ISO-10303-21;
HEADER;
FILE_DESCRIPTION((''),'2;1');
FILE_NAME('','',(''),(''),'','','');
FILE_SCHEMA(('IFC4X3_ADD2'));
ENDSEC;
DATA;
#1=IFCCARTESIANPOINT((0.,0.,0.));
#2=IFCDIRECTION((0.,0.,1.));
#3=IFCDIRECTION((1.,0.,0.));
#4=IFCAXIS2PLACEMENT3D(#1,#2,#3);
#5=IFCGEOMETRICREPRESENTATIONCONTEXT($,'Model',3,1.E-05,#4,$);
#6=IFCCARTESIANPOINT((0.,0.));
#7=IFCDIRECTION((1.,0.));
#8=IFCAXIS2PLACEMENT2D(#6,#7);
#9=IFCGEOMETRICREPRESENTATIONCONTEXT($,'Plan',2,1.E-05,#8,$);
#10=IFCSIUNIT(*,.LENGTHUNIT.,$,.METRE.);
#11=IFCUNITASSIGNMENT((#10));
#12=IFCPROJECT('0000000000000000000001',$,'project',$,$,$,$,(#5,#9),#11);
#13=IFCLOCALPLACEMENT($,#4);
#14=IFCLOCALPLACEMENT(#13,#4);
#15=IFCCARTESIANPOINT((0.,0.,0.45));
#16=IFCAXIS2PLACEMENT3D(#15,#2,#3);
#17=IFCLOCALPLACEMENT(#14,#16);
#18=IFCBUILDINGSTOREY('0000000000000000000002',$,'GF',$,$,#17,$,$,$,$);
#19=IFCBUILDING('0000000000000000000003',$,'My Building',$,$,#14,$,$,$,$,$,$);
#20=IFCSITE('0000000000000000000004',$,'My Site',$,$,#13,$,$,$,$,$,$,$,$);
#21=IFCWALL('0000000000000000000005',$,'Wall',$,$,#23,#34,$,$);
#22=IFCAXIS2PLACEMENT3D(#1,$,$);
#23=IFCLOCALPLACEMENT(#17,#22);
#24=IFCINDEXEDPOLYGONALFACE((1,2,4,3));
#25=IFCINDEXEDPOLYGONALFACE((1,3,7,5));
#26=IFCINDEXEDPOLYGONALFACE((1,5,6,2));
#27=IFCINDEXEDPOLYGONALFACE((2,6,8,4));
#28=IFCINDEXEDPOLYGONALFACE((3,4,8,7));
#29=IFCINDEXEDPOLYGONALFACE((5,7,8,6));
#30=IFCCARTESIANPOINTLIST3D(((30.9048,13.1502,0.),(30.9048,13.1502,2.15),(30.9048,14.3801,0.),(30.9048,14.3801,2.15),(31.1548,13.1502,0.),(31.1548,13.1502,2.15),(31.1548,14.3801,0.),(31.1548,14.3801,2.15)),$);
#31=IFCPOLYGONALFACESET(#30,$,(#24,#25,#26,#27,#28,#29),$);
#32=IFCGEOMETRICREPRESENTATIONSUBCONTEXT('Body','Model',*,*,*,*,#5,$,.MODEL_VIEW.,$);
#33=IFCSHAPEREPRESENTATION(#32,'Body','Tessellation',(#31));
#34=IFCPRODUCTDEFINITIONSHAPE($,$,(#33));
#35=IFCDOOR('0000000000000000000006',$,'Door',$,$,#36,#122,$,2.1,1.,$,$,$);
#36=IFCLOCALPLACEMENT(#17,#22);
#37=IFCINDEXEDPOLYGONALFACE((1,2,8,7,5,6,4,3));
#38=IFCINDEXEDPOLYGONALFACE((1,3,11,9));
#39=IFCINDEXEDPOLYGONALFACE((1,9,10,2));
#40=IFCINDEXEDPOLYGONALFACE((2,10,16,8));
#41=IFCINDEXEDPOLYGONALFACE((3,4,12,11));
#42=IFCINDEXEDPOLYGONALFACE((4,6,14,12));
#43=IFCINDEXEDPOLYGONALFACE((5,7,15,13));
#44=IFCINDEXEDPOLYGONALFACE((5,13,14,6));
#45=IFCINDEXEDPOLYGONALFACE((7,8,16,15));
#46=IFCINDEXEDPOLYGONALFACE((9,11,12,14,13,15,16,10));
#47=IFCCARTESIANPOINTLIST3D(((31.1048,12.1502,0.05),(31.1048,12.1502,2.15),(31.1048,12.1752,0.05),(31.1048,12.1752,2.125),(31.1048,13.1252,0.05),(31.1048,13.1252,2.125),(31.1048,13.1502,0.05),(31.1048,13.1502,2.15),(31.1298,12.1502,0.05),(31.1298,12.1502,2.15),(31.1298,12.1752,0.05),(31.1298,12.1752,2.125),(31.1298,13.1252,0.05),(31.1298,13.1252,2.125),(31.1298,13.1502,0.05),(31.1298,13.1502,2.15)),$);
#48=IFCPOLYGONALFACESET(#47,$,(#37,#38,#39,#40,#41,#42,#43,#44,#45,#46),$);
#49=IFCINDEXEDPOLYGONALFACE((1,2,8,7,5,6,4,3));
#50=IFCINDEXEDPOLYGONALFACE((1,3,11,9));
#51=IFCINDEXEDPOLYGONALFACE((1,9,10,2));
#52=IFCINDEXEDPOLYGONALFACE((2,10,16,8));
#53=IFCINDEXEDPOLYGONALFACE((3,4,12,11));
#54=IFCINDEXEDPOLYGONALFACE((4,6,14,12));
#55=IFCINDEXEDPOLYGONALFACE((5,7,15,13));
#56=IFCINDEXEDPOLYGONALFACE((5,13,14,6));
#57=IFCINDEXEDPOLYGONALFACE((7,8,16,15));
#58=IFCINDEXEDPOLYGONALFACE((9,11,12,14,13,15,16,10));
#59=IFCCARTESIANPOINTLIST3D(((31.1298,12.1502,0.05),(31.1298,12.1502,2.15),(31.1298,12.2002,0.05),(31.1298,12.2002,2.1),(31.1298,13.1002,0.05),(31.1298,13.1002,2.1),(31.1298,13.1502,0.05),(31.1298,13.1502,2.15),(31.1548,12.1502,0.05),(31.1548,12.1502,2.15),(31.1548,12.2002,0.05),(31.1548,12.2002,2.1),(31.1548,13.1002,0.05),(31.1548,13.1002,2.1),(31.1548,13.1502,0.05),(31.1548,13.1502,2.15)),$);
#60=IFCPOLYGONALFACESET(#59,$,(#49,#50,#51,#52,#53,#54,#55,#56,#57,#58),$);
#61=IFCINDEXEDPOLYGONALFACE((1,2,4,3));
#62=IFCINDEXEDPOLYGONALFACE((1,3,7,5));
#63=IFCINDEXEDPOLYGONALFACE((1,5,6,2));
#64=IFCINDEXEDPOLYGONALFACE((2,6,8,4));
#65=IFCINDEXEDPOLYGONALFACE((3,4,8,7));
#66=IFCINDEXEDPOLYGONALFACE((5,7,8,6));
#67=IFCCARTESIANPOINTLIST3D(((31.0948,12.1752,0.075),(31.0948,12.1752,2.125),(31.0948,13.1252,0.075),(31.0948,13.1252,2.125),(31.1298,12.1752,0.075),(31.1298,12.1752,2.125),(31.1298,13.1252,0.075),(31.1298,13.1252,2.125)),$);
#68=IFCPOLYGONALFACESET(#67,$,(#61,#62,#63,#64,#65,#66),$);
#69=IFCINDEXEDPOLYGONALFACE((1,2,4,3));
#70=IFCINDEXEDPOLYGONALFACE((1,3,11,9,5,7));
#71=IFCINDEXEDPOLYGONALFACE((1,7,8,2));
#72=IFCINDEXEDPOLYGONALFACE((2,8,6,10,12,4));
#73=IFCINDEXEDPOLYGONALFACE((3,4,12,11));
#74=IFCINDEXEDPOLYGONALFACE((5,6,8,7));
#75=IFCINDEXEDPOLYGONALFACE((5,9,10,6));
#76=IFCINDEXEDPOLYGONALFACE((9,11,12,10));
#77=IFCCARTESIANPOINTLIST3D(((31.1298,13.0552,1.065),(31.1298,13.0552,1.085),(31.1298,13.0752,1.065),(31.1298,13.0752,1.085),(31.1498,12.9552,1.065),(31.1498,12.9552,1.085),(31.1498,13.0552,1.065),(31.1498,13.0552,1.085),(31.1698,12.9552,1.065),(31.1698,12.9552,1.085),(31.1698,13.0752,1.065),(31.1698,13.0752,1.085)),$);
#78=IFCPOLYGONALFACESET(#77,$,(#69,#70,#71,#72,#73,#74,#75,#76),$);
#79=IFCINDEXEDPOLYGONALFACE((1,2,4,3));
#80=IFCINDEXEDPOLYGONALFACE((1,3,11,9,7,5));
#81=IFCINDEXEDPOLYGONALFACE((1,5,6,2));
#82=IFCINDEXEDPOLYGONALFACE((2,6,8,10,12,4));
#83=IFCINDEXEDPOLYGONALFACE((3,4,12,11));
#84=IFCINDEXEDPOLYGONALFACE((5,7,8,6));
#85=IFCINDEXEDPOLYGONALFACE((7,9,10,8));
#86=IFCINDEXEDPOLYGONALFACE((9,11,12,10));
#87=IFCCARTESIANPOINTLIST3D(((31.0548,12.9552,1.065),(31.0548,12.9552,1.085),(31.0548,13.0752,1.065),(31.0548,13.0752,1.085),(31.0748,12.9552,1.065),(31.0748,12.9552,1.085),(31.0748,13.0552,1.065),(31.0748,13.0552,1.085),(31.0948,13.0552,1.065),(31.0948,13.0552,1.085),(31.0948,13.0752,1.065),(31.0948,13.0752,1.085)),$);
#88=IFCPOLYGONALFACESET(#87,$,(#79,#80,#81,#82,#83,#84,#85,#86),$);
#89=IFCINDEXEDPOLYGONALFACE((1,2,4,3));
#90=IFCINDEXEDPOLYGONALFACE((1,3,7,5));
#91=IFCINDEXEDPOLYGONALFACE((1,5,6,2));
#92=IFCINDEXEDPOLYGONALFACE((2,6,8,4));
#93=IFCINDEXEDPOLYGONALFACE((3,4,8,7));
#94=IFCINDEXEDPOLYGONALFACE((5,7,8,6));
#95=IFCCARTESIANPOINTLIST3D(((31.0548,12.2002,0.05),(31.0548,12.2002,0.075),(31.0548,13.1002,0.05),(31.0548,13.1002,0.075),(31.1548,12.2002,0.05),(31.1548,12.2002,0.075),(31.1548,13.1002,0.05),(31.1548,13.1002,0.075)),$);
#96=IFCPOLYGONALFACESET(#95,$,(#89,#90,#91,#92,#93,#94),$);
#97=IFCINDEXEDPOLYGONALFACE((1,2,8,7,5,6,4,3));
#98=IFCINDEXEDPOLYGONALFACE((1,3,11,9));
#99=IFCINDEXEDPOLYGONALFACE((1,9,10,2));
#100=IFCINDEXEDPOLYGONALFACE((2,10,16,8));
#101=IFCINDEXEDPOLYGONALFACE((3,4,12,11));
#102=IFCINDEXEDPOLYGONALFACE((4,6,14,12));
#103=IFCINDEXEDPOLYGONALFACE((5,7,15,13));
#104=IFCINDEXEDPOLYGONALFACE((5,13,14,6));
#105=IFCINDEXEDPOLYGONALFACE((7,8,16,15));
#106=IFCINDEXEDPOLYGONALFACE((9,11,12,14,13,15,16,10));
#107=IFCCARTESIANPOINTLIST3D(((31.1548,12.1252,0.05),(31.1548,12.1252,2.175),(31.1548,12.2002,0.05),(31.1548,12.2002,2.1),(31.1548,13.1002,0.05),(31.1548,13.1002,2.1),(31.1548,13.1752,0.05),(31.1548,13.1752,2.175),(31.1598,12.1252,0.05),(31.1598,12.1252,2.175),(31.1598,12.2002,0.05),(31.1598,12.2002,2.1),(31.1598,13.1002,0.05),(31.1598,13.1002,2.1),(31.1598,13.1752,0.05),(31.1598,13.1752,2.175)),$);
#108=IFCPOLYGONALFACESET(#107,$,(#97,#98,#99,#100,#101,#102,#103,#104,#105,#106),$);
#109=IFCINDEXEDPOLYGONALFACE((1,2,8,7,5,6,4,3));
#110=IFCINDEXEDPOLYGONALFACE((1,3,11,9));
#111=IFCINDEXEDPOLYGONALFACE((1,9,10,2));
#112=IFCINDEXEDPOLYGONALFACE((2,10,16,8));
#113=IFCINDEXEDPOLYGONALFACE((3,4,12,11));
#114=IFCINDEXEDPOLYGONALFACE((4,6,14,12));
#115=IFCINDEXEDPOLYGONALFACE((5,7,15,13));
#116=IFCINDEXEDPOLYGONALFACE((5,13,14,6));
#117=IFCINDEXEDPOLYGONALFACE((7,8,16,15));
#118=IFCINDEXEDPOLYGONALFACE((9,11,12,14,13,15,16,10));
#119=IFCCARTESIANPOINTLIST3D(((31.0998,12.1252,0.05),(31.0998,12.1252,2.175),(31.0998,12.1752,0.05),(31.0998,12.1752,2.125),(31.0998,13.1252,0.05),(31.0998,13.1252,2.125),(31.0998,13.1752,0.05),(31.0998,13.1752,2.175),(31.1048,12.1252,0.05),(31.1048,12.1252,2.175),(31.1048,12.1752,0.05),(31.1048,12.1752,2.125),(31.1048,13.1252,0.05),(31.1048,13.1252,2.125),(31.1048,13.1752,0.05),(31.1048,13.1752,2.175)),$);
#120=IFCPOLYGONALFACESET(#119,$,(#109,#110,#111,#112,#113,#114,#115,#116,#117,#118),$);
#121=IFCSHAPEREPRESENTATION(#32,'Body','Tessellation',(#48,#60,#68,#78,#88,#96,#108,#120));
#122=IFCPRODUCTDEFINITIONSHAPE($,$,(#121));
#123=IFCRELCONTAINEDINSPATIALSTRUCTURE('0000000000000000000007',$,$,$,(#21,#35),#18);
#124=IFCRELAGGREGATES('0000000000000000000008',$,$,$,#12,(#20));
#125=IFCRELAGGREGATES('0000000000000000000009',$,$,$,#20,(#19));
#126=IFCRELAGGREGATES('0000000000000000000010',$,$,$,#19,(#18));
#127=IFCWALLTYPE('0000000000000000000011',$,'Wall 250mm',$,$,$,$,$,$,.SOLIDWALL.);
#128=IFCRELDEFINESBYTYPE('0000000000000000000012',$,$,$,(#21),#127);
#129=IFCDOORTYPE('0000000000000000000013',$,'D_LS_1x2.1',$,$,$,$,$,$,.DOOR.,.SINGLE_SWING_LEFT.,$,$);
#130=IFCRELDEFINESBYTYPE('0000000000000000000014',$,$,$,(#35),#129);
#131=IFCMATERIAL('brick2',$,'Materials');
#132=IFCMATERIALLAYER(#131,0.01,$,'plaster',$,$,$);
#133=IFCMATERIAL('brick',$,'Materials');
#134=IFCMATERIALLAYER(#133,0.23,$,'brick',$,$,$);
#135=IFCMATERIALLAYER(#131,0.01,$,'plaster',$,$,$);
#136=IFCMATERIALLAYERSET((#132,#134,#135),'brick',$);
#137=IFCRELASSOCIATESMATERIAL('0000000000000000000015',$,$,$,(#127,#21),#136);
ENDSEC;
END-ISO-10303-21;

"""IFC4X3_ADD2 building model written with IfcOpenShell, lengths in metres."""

from ifc_helpers import new_model, entity, si_unit, frame, origin_with_axes, origin_2d_with_axis, place, context, subcontext, project, spatial, line, indexed_curve, outline, extrude, shape, source, transform, mapped, material, layer, layer_set, layer_usage, type_object, type_shapes, element, fill, save


model = new_model("IFC4X3_ADD2")

# Units and contexts
model_context = context("Model", 3, precision=1e-05, world=origin_with_axes())
plan_context = context("Plan", 2, precision=1e-05, world=origin_2d_with_axis())
body_context_1 = subcontext(model_context, "Body", "Model", "MODEL_VIEW")
body_context_2 = subcontext(plan_context, "Body", "Plan", "PLAN_VIEW")
ifc_project = project(units=[si_unit("LENGTHUNIT", "METRE")], contexts=[model_context, plan_context])

# Site, building, storey
site_placement = place(None, origin_with_axes())
site = spatial("IfcSite", under=ifc_project, at=site_placement, Name="My Site")
building_placement = place(site_placement, origin_with_axes())
building = spatial("IfcBuilding", under=site, at=building_placement, Name="My Building")
storey_placement = place(building_placement, frame((0.0, 0.0, 0.45), z_axis=(0.0, 0.0, 1.0), x_axis=(1.0, 0.0, 0.0)))
storey = spatial("IfcBuildingStorey", under=building, at=storey_placement, Name="GF")

# Shared definitions
ifc_material_1 = material(Name="brick2", Category="Materials")
ifc_layer_1 = layer(ifc_material_1, 0.01, Name="plaster")
ifc_material_2 = material(Name="brick", Category="Materials")
ifc_layer_2 = layer(ifc_material_2, 0.23, Name="brick")
ifc_layer_3 = layer(ifc_material_1, 0.01, Name="plaster")
ifc_layer_set_1 = layer_set([ifc_layer_1, ifc_layer_2, ifc_layer_3], Name="brick")
wall_type_1 = type_object("IfcWallType", Name="Wall 250mm", PredefinedType="SOLIDWALL", material=ifc_layer_set_1)

# Wall, opening, door
ifc_layer_usage_1 = layer_usage(ifc_layer_set_1, "AXIS2", "POSITIVE", 0.0)
wall_1_placement = place(storey_placement, frame((31.1548, 12.1502, 0.0), z_axis=(0.0, 0.0, 1.0), x_axis=(0.000001, 1.0, 0.0)))
wall_1 = element("IfcWall", 1, at=wall_1_placement, inside=storey, type_object=wall_type_1, material=ifc_layer_usage_1, Name="Wall", context=body_context_1, shape_type="SweptSolid", body=[
    extrude(outline(indexed_curve([(0.0, 0.0), (0.0, 0.25), (2.2299, 0.25), (2.2299, 0.0)], segments=[line(1, 2, 3, 4, 1)])), origin_with_axes(), (0.0, 0.0, 1.0), 2.15),
])
shared_shape_1 = source(origin_with_axes(), body_context_1, "Body", "SweptSolid", [
    extrude(outline(indexed_curve([(0.0, 2.1), (1.0, 2.1), (1.0, -0.05), (0.0, -0.05), (0.0, 2.1)])), frame((0.0, -0.6, 0.0), z_axis=(0.0, -1.0, 0.0), x_axis=(1.0, 0.0, 0.0)), (0.0, 0.0, -1.0), 1.2),
])
opening_1_placement = place(wall_1_placement, frame((0.0, 0.0, 0.05), z_axis=(0.0, 0.0, 1.0), x_axis=(1.0, 0.0, 0.0)))
opening_1 = element("IfcOpeningElement", 2, at=opening_1_placement, cuts=wall_1, PredefinedType="OPENING", context=body_context_1, shape_type="MappedRepresentation", body=[
    mapped(shared_shape_1, transform((0.0, 0.0, 0.0), x_axis=(1.0, 0.0, 0.0), y_axis=(0.0, 1.0, 0.0), z_axis=(0.0, 0.0, 1.0), scale=1.0)),
])
door_type_1 = type_object("IfcDoorType", Name="D_LS_1x2.1", OperationType="SINGLE_SWING_LEFT", PredefinedType="DOOR")
shared_shape_2 = source(origin_with_axes(), body_context_1, "Body", "SweptSolid", [
    extrude(outline(indexed_curve([(0.0, 0.0), (0.0, 2.1), (1.0, 2.1), (1.0, 0.0), (0.975, 0.0), (0.975, 2.075), (0.025, 2.075), (0.025, 0.0)], segments=[line(1, 2, 3, 4, 5, 6, 7, 8, 1)])), frame((0.0, 0.025, 0.0), z_axis=(0.0, -1.0, 0.0), x_axis=(1.0, 0.0, 0.0)), (0.0, 0.0, -1.0), 0.025),
    extrude(outline(indexed_curve([(0.0, 0.0), (0.0, 2.1), (1.0, 2.1), (1.0, 0.0), (0.95, 0.0), (0.95, 2.05), (0.05, 2.05), (0.05, 0.0)], segments=[line(1, 2, 3, 4, 5, 6, 7, 8, 1)])), frame((0.0, 0.0, 0.0), z_axis=(0.0, -1.0, 0.0), x_axis=(1.0, 0.0, 0.0)), (0.0, 0.0, -1.0), 0.025),
    extrude(outline(indexed_curve([(0.0, 0.0), (0.95, 0.0), (0.95, 0.035), (0.0, 0.035)], segments=[line(1, 2, 3, 4, 1)])), frame((0.025, 0.025, 0.025), z_axis=(0.0, 0.0, 1.0), x_axis=(1.0, 0.0, 0.0)), (0.0, 0.0, 1.0), 2.05),
    extrude(outline(indexed_curve([(0.0, 0.0), (0.0, -0.04), (-0.12, -0.04), (-0.12, -0.02), (-0.02, -0.02), (-0.02, 0.0)], segments=[line(1, 2, 3, 4, 5, 6, 1)])), frame((0.925, 0.025, 1.015), z_axis=(0.0, 0.0, 1.0), x_axis=(1.0, 0.0, 0.0)), (0.0, 0.0, 1.0), 0.02),
    extrude(outline(indexed_curve([(0.0, 0.0), (0.0, 0.04), (-0.12, 0.04), (-0.12, 0.02), (-0.02, 0.02), (-0.02, 0.0)], segments=[line(1, 2, 3, 4, 5, 6, 1)])), frame((0.925, 0.06, 1.015), z_axis=(0.0, 0.0, 1.0), x_axis=(1.0, 0.0, 0.0)), (0.0, 0.0, 1.0), 0.02),
    extrude(outline(indexed_curve([(0.0, 0.0), (0.9, 0.0), (0.9, 0.1), (0.0, 0.1)], segments=[line(1, 2, 3, 4, 1)])), frame((0.05, 0.0, 0.0), z_axis=(0.0, 0.0, 1.0), x_axis=(1.0, 0.0, 0.0)), (0.0, 0.0, 1.0), 0.025),
    extrude(outline(indexed_curve([(0.0, 0.0), (0.0, 2.125), (1.05, 2.125), (1.05, 0.0), (0.975, 0.0), (0.975, 2.05), (0.075, 2.05), (0.075, 0.0)], segments=[line(1, 2, 3, 4, 5, 6, 7, 8, 1)])), frame((-0.025, -0.005, 0.0), z_axis=(0.0, -1.0, 0.0), x_axis=(1.0, 0.0, 0.0)), (0.0, 0.0, -1.0), 0.005),
    extrude(outline(indexed_curve([(0.0, 0.0), (0.0, 2.125), (1.05, 2.125), (1.05, 0.0), (1.0, 0.0), (1.0, 2.075), (0.05, 2.075), (0.05, 0.0)], segments=[line(1, 2, 3, 4, 5, 6, 7, 8, 1)])), frame((-0.025, 0.05, 0.0), z_axis=(0.0, -1.0, 0.0), x_axis=(1.0, 0.0, 0.0)), (0.0, 0.0, -1.0), 0.005),
])
shared_shape_3 = source(origin_with_axes(), body_context_2, "Body", "Curve2D", [
    entity("IfcIndexedPolyCurve", entity("IfcCartesianPointList2D", [[0.0, 0.0], [0.0, 0.05], [0.025, 0.05], [0.025, 0.025], [0.05, 0.025], [0.05, 0.0]]), [entity("IfcLineIndex", [1, 2, 3, 4, 5, 6, 1])]),
    entity("IfcIndexedPolyCurve", entity("IfcCartesianPointList2D", [[1.0, 0.0], [1.0, 0.05], [0.975, 0.05], [0.975, 0.025], [0.95, 0.025], [0.95, 0.0]]), [entity("IfcLineIndex", [1, 2, 3, 4, 5, 6, 1])]),
    entity("IfcTrimmedCurve", entity("IfcEllipse", entity("IfcAxis2Placement2D", entity("IfcCartesianPoint", [0.06, 0.05]), entity("IfcDirection", [1.0, 0.0])), 0.915, 0.95), [entity("IfcCartesianPoint", [0.975, 0.05])], [entity("IfcCartesianPoint", [0.06, 1.0])], True, "CARTESIAN"),
    entity("IfcIndexedPolyCurve", entity("IfcCartesianPointList2D", [[0.025, 0.05], [0.06, 0.05], [0.06, 1.0], [0.025, 1.0]]), [entity("IfcLineIndex", [1, 2, 3, 4, 1])]),
])
type_shapes(door_type_1, [shared_shape_2, shared_shape_3])
door_1_placement = place(opening_1_placement, frame((0.0, 0.0, 0.0), z_axis=(0.0, 0.0, 1.0), x_axis=(1.0, 0.0, 0.0)))
door_1 = element("IfcDoor", 3, at=door_1_placement, inside=storey, type_object=door_type_1, Name="Door", OverallHeight=2.1, OverallWidth=1.0, shapes=[
    shape(body_context_1, "Body", "MappedRepresentation", [mapped(shared_shape_2, transform((0.0, 0.0, 0.0), x_axis=(1.0, 0.0, 0.0), y_axis=(0.0, 1.0, 0.0), z_axis=(0.0, 0.0, 1.0), scale=1.0))]),
    shape(body_context_2, "Body", "MappedRepresentation", [mapped(shared_shape_3, transform((0.0, 0.0, 0.0), x_axis=(1.0, 0.0, 0.0), y_axis=(0.0, 1.0, 0.0), z_axis=(0.0, 0.0, 1.0), scale=1.0))]),
])
fill(opening_1, door_1)

save(model, "model.ifc")
